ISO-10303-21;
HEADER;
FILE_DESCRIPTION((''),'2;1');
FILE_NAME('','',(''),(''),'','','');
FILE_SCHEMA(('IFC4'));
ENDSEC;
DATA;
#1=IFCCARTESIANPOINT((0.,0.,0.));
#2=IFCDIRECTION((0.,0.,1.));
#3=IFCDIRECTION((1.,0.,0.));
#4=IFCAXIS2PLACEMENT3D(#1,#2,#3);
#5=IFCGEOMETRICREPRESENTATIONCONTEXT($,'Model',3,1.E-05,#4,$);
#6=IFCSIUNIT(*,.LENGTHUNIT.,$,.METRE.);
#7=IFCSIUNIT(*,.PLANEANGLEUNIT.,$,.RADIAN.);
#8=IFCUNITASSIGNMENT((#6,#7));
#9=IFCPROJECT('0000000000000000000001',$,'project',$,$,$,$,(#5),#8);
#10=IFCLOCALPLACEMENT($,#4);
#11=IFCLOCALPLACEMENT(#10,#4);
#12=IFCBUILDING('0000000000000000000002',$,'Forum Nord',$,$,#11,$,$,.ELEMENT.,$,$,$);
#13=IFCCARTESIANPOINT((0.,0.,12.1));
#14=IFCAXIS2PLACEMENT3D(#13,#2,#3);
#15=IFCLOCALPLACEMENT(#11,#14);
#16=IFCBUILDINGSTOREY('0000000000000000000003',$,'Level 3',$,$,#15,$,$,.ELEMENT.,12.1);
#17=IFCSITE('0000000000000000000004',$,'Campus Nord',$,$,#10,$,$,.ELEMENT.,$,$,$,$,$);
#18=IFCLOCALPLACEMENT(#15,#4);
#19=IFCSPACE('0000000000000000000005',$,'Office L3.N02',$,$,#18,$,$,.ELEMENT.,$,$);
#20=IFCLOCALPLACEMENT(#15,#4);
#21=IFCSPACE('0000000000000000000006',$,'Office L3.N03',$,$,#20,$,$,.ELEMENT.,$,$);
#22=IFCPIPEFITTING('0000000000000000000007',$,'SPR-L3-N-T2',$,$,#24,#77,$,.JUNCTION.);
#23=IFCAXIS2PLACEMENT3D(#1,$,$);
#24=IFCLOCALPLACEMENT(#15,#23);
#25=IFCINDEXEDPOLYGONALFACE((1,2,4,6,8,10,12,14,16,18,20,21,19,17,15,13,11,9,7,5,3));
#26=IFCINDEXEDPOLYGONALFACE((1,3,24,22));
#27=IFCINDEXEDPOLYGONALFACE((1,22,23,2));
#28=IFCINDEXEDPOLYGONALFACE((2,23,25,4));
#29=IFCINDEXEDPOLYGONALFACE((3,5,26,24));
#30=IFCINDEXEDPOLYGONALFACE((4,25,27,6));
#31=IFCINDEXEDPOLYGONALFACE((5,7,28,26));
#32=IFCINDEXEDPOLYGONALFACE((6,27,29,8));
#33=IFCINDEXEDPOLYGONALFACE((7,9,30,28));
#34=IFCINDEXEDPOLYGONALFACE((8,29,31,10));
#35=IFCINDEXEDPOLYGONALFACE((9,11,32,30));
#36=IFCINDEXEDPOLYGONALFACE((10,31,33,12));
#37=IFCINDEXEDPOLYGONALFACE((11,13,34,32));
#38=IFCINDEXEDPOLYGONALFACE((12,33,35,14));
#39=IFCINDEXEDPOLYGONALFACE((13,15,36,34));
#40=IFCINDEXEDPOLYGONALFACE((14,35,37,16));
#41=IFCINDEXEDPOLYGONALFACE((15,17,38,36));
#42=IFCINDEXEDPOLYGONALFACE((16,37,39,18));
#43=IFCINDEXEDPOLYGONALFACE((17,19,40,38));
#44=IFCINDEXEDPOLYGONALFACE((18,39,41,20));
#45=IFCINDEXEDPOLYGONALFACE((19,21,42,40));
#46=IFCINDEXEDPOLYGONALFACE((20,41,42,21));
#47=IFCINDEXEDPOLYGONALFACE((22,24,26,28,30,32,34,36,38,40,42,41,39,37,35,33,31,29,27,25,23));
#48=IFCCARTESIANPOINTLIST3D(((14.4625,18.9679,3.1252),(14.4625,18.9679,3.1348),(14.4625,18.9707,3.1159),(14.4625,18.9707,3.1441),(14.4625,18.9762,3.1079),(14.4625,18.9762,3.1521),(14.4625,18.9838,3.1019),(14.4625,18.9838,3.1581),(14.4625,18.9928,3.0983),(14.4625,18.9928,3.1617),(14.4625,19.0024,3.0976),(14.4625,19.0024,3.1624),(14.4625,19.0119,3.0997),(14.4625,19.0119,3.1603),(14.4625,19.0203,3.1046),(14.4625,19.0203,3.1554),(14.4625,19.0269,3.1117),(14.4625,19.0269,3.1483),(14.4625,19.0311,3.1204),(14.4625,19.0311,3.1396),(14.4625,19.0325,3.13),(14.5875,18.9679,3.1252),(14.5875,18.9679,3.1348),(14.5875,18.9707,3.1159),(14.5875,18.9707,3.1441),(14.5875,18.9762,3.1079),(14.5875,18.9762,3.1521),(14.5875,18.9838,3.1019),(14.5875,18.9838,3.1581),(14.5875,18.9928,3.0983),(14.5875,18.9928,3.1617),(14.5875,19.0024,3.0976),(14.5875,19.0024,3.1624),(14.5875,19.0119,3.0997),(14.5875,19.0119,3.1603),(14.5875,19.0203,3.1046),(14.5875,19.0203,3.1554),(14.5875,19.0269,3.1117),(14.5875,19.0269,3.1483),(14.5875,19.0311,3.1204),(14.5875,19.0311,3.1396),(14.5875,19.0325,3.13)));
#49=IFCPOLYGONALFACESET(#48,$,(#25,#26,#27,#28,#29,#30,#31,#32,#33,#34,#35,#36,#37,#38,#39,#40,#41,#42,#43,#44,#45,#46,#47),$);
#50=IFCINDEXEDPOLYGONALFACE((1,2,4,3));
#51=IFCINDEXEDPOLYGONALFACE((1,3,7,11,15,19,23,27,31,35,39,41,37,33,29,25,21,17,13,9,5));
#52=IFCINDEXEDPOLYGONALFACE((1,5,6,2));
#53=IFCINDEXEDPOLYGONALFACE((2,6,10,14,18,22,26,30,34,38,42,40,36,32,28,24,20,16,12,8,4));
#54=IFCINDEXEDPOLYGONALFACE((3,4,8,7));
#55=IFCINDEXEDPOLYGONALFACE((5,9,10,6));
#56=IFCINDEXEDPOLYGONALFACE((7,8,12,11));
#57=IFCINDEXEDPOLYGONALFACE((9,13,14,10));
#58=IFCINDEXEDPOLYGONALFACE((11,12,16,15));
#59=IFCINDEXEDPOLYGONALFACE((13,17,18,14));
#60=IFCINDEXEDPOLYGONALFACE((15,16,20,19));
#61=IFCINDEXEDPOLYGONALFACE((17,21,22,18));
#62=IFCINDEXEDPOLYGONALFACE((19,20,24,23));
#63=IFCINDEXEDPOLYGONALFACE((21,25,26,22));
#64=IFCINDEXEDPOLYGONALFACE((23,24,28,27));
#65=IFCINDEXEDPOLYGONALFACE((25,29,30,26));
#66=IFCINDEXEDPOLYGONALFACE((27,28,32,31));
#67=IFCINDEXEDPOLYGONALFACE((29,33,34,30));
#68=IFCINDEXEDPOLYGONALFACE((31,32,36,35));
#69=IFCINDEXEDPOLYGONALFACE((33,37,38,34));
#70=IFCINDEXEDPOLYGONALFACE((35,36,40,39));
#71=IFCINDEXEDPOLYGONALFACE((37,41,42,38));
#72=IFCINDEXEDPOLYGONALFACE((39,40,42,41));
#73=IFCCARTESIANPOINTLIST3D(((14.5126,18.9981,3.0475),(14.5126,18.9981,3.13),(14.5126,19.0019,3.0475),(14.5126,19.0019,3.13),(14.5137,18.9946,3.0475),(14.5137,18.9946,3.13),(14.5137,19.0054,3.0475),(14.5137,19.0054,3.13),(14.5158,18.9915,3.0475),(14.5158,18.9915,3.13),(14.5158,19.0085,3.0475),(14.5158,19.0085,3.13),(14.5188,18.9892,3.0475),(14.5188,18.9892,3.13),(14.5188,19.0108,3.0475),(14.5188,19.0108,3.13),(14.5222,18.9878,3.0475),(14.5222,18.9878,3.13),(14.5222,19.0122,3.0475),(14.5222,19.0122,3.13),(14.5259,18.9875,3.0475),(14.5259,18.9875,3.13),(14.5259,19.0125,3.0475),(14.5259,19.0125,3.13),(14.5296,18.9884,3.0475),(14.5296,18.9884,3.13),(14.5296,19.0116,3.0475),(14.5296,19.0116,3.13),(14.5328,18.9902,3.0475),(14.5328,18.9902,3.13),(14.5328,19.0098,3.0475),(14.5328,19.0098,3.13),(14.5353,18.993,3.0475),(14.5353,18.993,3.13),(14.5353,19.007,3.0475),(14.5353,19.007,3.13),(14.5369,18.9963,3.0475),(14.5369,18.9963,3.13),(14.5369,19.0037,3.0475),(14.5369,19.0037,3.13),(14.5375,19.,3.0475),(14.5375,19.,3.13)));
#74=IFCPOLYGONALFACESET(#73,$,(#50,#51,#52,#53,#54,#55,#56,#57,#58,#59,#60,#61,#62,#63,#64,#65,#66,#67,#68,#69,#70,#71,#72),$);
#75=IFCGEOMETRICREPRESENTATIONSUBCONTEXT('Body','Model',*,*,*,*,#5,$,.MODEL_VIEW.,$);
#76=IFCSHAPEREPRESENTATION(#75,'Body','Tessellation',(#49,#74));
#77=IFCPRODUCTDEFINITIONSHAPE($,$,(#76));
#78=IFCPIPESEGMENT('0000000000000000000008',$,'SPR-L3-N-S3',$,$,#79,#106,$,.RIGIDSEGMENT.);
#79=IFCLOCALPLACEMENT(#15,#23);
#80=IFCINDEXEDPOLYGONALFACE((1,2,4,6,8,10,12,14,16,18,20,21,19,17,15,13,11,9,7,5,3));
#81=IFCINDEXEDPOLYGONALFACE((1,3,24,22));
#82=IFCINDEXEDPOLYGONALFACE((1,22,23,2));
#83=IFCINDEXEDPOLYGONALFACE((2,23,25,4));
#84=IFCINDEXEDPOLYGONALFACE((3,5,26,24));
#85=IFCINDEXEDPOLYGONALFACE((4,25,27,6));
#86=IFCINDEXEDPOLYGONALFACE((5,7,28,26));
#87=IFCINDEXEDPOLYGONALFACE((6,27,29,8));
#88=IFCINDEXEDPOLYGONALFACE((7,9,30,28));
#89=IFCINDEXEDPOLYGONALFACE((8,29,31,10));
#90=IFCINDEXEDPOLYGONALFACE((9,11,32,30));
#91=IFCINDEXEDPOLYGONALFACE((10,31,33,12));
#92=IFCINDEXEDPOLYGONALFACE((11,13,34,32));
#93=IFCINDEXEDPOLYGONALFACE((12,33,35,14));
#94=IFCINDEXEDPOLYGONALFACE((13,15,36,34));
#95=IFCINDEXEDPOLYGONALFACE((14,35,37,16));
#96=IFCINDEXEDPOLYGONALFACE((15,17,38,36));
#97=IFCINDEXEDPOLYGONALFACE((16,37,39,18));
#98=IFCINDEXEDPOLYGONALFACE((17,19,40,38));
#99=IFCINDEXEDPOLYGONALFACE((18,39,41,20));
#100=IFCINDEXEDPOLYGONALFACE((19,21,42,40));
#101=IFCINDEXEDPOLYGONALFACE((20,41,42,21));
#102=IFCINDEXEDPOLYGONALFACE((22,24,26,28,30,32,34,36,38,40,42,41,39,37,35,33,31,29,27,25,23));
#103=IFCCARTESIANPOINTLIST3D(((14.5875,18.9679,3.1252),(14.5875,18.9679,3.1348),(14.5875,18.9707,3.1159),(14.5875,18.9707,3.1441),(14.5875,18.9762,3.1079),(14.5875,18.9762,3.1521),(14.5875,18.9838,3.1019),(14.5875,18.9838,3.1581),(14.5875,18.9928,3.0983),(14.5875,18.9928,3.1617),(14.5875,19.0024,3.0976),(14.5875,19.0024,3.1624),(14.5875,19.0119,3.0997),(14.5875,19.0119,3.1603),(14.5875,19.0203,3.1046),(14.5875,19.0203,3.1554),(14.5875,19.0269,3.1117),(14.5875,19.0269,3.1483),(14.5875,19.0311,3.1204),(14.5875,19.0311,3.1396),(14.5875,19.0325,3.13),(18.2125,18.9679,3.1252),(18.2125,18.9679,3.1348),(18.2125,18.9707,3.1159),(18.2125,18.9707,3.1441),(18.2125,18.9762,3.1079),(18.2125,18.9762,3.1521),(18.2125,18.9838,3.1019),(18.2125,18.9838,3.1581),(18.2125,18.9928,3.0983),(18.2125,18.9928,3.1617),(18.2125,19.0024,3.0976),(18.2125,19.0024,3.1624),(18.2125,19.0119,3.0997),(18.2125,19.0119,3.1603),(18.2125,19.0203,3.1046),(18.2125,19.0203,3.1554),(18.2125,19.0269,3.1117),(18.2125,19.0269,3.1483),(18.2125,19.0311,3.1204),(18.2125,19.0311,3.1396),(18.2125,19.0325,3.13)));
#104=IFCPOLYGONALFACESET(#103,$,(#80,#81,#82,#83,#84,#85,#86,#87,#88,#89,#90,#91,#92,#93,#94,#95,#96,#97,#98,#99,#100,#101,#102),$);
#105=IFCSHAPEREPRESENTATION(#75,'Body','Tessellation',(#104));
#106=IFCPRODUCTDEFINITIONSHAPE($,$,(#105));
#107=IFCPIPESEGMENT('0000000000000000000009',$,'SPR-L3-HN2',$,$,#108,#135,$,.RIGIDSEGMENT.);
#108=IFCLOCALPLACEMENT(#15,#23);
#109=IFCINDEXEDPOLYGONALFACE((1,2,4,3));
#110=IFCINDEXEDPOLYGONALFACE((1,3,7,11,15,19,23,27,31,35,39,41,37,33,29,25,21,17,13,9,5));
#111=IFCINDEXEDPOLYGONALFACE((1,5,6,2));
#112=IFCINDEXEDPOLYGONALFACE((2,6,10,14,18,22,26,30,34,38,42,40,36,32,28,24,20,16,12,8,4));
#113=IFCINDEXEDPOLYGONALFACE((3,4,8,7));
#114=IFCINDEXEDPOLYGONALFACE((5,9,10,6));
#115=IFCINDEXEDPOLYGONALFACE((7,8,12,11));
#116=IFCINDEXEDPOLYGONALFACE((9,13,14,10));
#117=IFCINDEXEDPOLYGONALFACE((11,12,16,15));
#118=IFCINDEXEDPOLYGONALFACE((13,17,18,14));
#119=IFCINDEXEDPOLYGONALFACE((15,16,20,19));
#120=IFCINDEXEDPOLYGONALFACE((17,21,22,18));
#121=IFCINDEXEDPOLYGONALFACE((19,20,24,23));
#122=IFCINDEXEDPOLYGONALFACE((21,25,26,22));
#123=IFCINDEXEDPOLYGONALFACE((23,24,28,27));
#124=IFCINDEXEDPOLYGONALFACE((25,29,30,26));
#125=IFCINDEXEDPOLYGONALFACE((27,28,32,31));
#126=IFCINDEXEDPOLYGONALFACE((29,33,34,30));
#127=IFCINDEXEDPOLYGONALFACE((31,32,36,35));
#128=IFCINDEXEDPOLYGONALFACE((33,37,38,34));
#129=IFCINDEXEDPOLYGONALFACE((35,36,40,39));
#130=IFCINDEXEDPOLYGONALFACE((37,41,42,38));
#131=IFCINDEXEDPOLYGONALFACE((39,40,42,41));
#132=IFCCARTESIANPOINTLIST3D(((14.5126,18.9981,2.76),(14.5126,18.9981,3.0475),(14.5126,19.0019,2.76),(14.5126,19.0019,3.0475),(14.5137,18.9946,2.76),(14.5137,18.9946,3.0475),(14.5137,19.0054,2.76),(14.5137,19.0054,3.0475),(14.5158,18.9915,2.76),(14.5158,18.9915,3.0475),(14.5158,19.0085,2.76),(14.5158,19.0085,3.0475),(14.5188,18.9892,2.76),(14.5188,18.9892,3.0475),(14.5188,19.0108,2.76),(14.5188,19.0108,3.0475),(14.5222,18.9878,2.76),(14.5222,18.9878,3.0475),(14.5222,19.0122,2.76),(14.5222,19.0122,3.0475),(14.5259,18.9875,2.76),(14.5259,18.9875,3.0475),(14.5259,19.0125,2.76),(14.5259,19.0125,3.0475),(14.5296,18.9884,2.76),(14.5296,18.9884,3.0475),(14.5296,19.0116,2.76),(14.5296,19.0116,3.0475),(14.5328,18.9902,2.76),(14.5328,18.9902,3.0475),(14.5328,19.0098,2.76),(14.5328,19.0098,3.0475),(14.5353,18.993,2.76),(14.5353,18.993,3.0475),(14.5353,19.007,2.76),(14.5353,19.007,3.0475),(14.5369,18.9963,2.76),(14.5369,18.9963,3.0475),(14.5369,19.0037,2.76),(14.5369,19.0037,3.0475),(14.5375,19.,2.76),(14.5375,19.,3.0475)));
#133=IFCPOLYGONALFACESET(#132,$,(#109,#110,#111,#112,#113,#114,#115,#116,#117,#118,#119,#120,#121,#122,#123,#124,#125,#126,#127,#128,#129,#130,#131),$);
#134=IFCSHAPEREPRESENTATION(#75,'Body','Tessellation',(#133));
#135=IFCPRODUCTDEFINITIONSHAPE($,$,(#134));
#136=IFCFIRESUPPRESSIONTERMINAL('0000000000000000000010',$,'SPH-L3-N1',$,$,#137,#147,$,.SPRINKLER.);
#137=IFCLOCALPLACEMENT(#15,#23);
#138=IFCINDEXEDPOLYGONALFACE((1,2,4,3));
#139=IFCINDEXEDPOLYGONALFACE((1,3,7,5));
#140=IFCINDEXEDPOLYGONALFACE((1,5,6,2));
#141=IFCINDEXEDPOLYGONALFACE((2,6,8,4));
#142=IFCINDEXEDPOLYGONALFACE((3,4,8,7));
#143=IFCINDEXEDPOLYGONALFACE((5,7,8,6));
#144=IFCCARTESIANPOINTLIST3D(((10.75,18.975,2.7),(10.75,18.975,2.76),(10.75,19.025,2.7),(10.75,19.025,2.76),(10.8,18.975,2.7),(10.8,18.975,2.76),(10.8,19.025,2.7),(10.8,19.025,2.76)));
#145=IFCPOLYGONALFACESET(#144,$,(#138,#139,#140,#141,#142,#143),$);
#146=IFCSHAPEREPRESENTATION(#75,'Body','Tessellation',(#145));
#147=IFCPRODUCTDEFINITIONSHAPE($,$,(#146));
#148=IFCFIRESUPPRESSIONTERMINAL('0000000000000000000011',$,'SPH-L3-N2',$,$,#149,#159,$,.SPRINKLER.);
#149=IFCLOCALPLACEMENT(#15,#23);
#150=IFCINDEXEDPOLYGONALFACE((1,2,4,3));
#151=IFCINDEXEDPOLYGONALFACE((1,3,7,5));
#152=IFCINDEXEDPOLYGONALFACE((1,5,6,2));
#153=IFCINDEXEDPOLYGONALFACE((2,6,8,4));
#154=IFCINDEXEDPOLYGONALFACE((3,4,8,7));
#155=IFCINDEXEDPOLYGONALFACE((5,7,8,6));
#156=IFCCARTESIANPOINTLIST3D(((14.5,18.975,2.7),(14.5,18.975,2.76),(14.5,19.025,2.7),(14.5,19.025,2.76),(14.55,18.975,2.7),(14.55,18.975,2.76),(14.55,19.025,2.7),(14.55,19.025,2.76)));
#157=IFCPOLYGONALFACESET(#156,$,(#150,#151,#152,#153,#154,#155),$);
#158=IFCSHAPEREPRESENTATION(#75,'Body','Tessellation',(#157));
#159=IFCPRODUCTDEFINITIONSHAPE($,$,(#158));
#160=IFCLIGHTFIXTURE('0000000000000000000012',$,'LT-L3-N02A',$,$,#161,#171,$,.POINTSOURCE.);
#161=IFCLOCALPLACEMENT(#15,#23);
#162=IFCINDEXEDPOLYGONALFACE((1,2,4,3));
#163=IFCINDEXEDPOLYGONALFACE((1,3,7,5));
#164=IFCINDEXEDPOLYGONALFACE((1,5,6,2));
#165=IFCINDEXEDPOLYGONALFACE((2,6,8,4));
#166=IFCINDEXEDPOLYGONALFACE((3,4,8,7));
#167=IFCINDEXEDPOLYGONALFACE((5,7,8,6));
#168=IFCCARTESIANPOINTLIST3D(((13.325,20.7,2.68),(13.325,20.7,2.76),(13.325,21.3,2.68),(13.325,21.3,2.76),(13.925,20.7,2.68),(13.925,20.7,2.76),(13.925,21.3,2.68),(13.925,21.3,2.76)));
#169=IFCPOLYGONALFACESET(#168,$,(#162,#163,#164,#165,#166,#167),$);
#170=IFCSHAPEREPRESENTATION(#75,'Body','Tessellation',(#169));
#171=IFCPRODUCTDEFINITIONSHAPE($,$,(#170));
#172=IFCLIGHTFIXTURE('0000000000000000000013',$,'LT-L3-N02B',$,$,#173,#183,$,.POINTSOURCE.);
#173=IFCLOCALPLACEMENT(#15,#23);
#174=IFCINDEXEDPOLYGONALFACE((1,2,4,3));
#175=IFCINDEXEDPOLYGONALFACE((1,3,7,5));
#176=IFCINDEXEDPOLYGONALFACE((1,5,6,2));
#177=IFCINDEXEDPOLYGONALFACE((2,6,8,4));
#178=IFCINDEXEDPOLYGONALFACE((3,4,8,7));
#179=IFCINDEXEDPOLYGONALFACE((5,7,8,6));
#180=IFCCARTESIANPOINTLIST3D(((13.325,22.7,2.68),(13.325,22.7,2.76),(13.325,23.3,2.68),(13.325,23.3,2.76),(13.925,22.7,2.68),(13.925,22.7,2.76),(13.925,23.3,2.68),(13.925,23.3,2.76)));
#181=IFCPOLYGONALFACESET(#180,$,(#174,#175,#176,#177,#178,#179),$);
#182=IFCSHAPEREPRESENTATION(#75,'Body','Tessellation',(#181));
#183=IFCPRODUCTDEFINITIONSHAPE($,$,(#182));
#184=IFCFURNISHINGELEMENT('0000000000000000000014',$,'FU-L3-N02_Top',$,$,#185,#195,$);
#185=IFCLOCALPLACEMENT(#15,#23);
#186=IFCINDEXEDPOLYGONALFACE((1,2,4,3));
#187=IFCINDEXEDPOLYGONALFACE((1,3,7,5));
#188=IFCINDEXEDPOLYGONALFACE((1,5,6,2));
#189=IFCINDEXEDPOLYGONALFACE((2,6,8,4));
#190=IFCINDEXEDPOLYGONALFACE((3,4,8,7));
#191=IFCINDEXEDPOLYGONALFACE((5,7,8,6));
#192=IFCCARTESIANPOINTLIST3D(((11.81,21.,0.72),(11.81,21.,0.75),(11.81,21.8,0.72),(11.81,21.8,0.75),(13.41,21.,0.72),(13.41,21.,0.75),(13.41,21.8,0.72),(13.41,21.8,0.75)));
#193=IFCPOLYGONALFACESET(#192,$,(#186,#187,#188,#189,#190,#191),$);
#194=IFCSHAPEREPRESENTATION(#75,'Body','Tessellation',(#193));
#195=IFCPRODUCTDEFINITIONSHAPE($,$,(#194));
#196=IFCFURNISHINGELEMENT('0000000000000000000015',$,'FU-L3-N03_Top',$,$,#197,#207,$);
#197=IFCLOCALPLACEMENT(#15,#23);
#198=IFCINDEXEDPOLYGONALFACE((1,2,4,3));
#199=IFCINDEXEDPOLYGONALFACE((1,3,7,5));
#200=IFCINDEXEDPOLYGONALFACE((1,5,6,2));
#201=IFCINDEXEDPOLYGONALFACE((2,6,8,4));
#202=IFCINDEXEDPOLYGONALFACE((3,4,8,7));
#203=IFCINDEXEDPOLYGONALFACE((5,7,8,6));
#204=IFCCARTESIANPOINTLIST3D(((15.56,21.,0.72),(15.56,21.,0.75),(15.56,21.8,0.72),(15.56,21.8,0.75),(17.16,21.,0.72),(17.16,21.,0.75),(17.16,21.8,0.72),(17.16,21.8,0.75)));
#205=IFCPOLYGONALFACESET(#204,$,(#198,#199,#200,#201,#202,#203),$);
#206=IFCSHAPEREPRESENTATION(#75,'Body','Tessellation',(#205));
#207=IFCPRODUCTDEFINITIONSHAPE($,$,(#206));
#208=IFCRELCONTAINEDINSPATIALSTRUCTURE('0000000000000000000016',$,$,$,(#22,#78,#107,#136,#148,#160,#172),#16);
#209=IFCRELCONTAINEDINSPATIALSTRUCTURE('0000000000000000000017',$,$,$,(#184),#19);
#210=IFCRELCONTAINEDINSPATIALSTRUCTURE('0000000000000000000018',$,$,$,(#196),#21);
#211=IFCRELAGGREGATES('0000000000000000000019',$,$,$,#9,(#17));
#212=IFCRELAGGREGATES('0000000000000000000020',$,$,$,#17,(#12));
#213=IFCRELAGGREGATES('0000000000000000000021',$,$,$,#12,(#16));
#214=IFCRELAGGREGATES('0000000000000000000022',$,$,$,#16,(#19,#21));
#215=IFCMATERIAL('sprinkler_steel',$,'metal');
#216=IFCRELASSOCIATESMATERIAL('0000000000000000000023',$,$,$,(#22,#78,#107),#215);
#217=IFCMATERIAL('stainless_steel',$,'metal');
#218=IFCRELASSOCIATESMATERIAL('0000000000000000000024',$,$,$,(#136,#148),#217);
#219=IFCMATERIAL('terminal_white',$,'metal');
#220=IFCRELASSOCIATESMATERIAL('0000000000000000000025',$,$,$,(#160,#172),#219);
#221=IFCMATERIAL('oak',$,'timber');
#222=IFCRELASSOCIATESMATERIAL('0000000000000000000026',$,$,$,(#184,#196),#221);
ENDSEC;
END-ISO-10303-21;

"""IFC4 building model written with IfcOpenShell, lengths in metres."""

from ifc_helpers import new_model, si_unit, frame, frame_2d, origin_with_axes, origin_2d_with_axis, place, context, subcontext, project, spatial, rectangle, circle, extrude, material, element, save


model = new_model("IFC4")

# Units and contexts
model_context = context("Model", 3, precision=1e-05, world=origin_with_axes())
body_context = subcontext(model_context, "Body", "Model", "MODEL_VIEW")
ifc_project = project(units=[si_unit("LENGTHUNIT", "METRE"), si_unit("PLANEANGLEUNIT", "RADIAN")], contexts=[model_context])

# Site, building, storey
site_placement = place(None, origin_with_axes())
site = spatial("IfcSite", under=ifc_project, at=site_placement, Name="Campus Nord", CompositionType="ELEMENT")
building_placement = place(site_placement, origin_with_axes())
building = spatial("IfcBuilding", under=site, at=building_placement, Name="Forum Nord", CompositionType="ELEMENT")
storey_placement = place(building_placement, frame((0.0, 0.0, 12.1), z_axis=(0.0, 0.0, 1.0), x_axis=(1.0, 0.0, 0.0)))
storey = spatial("IfcBuildingStorey", under=building, at=storey_placement, Name="Level 3", CompositionType="ELEMENT", Elevation=12.1)

# Shared definitions
ifc_material_1 = material(Name="terminal_white", Category="metal")

# Shared definitions
ifc_material_2 = material(Name="sprinkler_steel", Category="metal")

# Pipe fitting
pipe_fitting_placement = place(storey_placement, frame((14.4625, 19.0, 3.13), z_axis=(1.0, 0.0, 0.0), x_axis=(0.0, 1.0, 0.0)))
element("IfcPipeFitting", 1, at=pipe_fitting_placement, inside=storey, material=ifc_material_2, Name="SPR-L3-N-T2", PredefinedType="JUNCTION", context=body_context, shape_type="SweptSolid", body=[
    extrude(circle(Radius=0.0325, at=origin_2d_with_axis()), origin_with_axes(), (0.0, 0.0, 1.0), 0.125),
    extrude(circle(Radius=0.0125, at=origin_2d_with_axis()), frame((0.0, 0.0, 0.0625), z_axis=(0.0, -1.0, 0.0), x_axis=(0.0, 0.0, 1.0)), (0.0, 0.0, 1.0), 0.0825),
])

# Pipe segments
pipe_segment_1_placement = place(storey_placement, frame((14.5875, 19.0, 3.13), z_axis=(1.0, 0.0, 0.0), x_axis=(0.0, 1.0, 0.0)))
element("IfcPipeSegment", 2, at=pipe_segment_1_placement, inside=storey, material=ifc_material_2, Name="SPR-L3-N-S3", PredefinedType="RIGIDSEGMENT", context=body_context, shape_type="SweptSolid", body=[
    extrude(circle(Radius=0.0325, at=origin_2d_with_axis()), origin_with_axes(), (0.0, 0.0, 1.0), 3.625),
])
pipe_segment_2_placement = place(storey_placement, frame((14.525, 19.0, 3.0475), z_axis=(0.0, 0.0, -1.0), x_axis=(1.0, 0.0, 0.0)))
element("IfcPipeSegment", 3, at=pipe_segment_2_placement, inside=storey, material=ifc_material_2, Name="SPR-L3-HN2", PredefinedType="RIGIDSEGMENT", context=body_context, shape_type="SweptSolid", body=[
    extrude(circle(Radius=0.0125, at=origin_2d_with_axis()), origin_with_axes(), (0.0, 0.0, 1.0), 0.2875),
])

# Fire suppression terminals
ifc_material_3 = material(Name="stainless_steel", Category="metal")
for number, where, z_axis, x_axis, name in (
    (4, (10.775, 19.0, 2.7), (0.0, 0.0, 1.0), (1.0, 0.0, 0.0), "SPH-L3-N1"),
    (5, (14.525, 19.0, 2.7), (0.0, 0.0, 1.0), (1.0, 0.0, 0.0), "SPH-L3-N2"),
):
    element("IfcFireSuppressionTerminal", number, at=place(storey_placement, frame(where, z_axis=z_axis, x_axis=x_axis)), inside=storey, material=ifc_material_3, Name=name, PredefinedType="SPRINKLER", context=body_context, shape_type="SweptSolid", body=[
        extrude(rectangle(XDim=0.05, YDim=0.05, at=origin_2d_with_axis()), origin_with_axes(), (0.0, 0.0, 1.0), 0.06),
    ])

# Light fixtures
for number, where, z_axis, x_axis, name in (
    (6, (13.625, 21.0, 2.68), (0.0, 0.0, 1.0), (1.0, 0.0, 0.0), "LT-L3-N02A"),
    (7, (13.625, 23.0, 2.68), (0.0, 0.0, 1.0), (1.0, 0.0, 0.0), "LT-L3-N02B"),
):
    element("IfcLightFixture", number, at=place(storey_placement, frame(where, z_axis=z_axis, x_axis=x_axis)), inside=storey, material=ifc_material_1, Name=name, PredefinedType="POINTSOURCE", context=body_context, shape_type="SweptSolid", body=[
        extrude(rectangle(XDim=0.6, YDim=0.6, at=origin_2d_with_axis()), origin_with_axes(), (0.0, 0.0, 1.0), 0.08),
    ])

# Shared definitions
space_1_placement = place(storey_placement, origin_with_axes())
space_1 = spatial("IfcSpace", under=storey, at=space_1_placement, Name="Office L3.N02", CompositionType="ELEMENT")

# Furnishing element
ifc_material_4 = material(Name="oak", Category="timber")
furnishing_1_placement = place(storey_placement, frame((13.41, 22.4, 0.0), z_axis=(0.0, 0.0, 1.0), x_axis=(-1.0, 0.0, 0.0)))
element("IfcFurnishingElement", 8, at=furnishing_1_placement, inside=space_1, material=ifc_material_4, Name="FU-L3-N02_Top", context=body_context, shape_type="SweptSolid", body=[
    extrude(rectangle(XDim=1.6, YDim=0.8, at=frame_2d((0.8, 1.0), x_axis=(1.0, 0.0))), frame((0.0, 0.0, 0.72), z_axis=(0.0, 0.0, 1.0), x_axis=(1.0, 0.0, 0.0)), (0.0, 0.0, 1.0), 0.03),
])

# Shared definitions
space_2_placement = place(storey_placement, origin_with_axes())
space_2 = spatial("IfcSpace", under=storey, at=space_2_placement, Name="Office L3.N03", CompositionType="ELEMENT")

# Furnishing element
furnishing_2_placement = place(storey_placement, frame((17.16, 22.4, 0.0), z_axis=(0.0, 0.0, 1.0), x_axis=(-1.0, 0.0, 0.0)))
element("IfcFurnishingElement", 9, at=furnishing_2_placement, inside=space_2, material=ifc_material_4, Name="FU-L3-N03_Top", context=body_context, shape_type="SweptSolid", body=[
    extrude(rectangle(XDim=1.6, YDim=0.8, at=frame_2d((0.8, 1.0), x_axis=(1.0, 0.0))), frame((0.0, 0.0, 0.72), z_axis=(0.0, 0.0, 1.0), x_axis=(1.0, 0.0, 0.0)), (0.0, 0.0, 1.0), 0.03),
])

save(model, "model.ifc")
